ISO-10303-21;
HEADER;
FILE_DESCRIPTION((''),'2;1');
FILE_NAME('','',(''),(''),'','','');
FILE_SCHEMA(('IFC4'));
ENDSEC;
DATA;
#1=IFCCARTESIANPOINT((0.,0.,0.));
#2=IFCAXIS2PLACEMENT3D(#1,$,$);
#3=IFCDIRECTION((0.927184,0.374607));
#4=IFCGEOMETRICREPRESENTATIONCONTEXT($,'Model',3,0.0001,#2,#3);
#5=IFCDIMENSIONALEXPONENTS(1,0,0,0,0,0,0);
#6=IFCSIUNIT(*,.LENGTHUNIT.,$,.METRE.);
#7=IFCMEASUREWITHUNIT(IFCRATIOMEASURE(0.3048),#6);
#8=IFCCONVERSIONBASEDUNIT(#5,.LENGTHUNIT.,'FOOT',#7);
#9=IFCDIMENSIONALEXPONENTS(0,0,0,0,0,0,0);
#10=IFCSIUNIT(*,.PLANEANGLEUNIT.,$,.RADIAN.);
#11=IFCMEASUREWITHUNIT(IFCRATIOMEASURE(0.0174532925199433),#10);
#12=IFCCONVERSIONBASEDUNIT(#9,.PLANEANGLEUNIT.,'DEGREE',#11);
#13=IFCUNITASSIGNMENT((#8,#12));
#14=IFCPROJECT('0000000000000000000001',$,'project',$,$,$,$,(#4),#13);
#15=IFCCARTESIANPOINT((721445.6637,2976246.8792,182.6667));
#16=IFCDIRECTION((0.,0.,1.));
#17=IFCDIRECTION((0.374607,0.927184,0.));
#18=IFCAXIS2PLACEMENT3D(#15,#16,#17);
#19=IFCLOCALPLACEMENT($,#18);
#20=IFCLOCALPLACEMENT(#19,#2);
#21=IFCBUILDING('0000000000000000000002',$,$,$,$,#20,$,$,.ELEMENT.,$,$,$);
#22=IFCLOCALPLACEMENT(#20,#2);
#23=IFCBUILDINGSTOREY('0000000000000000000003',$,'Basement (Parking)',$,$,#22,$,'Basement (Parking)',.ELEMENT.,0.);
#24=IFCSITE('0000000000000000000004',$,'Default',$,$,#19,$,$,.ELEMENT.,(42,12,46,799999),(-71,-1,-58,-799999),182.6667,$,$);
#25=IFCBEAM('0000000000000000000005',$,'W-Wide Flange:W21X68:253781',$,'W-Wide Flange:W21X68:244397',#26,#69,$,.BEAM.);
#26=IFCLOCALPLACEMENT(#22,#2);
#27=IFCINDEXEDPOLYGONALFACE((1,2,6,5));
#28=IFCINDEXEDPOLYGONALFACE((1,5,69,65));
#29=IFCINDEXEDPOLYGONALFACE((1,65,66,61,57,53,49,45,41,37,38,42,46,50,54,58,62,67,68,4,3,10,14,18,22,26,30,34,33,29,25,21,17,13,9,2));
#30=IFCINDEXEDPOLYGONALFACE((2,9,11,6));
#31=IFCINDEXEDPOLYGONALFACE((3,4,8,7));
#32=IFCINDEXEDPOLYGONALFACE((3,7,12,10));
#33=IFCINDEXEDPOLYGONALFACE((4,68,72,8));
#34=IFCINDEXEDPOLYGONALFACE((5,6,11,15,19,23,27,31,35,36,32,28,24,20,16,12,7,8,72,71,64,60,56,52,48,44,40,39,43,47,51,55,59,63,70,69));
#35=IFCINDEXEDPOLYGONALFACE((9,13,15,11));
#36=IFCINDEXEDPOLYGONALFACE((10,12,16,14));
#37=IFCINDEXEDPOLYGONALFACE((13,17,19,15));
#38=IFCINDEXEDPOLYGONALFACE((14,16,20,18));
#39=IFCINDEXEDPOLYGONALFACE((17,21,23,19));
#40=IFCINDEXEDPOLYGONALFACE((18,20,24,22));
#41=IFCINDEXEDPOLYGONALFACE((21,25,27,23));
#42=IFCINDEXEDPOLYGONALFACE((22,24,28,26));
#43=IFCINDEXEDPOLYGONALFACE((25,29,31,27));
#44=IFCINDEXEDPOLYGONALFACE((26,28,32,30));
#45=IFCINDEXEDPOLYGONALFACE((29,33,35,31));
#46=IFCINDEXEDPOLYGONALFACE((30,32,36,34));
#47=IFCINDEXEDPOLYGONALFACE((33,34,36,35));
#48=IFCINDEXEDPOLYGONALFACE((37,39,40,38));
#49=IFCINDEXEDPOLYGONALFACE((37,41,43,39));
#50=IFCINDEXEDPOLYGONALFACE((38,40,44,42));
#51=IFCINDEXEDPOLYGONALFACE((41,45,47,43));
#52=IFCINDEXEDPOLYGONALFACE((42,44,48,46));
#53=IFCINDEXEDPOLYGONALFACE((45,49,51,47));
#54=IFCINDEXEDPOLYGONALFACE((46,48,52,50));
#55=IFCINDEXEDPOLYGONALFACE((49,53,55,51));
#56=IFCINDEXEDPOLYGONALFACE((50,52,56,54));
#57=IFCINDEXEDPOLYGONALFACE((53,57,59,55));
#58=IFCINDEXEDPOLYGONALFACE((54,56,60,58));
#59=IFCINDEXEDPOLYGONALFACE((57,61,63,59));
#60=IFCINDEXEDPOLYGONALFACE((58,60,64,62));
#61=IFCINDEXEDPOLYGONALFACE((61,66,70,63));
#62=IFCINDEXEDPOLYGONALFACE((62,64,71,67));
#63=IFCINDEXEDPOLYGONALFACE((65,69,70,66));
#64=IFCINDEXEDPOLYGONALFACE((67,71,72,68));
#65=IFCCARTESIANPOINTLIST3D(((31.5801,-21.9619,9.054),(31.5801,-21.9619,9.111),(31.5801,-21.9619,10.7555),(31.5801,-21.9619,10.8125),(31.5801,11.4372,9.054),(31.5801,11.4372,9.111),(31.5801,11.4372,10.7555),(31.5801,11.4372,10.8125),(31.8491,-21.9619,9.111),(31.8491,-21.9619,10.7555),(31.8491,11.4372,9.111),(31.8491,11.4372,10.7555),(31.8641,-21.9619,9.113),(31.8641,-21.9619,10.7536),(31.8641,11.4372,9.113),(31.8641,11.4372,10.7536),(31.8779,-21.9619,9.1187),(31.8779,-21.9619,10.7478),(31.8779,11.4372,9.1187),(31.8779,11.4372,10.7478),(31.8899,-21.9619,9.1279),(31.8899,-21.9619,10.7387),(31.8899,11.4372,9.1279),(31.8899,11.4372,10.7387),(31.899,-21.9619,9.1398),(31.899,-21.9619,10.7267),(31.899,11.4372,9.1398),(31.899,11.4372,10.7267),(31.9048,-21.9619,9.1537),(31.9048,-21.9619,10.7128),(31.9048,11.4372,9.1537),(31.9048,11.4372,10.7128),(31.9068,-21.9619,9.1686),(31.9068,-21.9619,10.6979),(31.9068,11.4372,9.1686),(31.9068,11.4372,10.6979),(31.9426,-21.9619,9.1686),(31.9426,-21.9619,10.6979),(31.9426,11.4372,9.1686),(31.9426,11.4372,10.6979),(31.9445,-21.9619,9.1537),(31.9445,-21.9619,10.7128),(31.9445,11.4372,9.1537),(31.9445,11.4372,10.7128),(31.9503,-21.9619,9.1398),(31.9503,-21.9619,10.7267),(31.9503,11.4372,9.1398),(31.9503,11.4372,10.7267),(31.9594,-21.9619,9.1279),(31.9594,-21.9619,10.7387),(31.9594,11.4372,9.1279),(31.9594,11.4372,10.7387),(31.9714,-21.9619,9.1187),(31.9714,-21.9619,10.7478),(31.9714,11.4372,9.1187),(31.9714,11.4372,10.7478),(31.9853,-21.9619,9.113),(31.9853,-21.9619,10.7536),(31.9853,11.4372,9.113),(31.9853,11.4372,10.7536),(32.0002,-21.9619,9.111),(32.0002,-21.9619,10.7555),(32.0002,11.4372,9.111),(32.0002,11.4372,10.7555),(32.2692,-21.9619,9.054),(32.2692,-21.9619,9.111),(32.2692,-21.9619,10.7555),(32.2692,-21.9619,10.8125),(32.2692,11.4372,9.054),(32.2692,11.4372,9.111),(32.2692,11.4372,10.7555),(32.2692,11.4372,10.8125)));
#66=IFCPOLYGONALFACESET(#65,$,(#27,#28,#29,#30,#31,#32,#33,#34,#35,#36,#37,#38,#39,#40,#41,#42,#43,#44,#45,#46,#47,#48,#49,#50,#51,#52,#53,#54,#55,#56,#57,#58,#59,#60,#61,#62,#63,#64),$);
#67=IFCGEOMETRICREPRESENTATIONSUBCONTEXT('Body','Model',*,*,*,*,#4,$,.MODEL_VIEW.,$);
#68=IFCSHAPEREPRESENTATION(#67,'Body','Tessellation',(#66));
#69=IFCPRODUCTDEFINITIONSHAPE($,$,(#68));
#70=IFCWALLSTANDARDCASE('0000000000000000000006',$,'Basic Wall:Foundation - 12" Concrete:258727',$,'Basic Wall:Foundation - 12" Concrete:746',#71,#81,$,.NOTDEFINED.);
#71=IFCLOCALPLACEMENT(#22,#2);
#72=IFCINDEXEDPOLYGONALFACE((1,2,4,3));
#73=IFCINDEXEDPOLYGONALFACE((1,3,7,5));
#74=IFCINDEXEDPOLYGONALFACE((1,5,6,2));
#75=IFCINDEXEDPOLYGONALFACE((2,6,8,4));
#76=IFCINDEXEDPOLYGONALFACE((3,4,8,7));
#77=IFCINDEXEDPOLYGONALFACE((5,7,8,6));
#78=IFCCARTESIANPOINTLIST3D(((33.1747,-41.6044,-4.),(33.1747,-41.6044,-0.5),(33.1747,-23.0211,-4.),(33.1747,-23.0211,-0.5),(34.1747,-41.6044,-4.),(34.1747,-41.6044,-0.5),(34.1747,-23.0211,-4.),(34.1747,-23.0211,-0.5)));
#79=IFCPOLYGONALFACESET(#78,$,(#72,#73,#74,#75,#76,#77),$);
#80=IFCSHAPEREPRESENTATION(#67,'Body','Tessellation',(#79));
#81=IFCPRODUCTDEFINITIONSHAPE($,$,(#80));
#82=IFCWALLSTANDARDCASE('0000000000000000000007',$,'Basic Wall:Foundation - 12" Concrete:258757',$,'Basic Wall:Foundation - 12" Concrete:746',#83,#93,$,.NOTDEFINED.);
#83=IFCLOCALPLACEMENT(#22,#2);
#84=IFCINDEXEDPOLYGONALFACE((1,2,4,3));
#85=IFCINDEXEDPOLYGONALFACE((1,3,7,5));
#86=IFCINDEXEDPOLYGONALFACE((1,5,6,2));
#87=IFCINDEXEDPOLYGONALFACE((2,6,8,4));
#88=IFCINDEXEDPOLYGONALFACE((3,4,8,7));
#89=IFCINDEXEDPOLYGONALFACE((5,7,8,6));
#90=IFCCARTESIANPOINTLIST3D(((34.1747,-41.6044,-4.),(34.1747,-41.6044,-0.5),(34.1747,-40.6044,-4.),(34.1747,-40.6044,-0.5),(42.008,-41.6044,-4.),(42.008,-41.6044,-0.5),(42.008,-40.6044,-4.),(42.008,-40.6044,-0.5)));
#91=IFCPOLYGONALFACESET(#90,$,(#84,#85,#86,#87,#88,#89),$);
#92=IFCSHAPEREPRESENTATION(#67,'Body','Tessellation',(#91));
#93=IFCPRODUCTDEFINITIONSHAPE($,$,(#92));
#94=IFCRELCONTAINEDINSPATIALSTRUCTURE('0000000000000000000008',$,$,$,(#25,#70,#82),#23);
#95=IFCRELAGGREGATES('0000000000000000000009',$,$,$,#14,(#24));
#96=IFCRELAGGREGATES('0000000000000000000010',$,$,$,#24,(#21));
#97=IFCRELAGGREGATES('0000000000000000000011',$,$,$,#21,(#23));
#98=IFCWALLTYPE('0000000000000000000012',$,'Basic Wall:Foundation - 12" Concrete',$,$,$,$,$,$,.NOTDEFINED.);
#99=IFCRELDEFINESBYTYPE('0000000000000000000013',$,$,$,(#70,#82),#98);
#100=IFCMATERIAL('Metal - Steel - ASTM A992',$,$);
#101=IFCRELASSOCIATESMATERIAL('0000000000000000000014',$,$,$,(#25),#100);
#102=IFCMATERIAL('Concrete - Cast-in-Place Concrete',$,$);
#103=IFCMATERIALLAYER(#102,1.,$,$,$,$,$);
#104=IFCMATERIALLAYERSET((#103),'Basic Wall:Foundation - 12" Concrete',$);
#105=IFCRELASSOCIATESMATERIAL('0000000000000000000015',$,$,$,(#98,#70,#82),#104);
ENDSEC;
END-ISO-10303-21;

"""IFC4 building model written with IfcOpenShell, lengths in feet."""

from ifc_helpers import new_model, entity, si_unit, converted_unit, direction, frame, frame_2d, origin, place, context, subcontext, project, spatial, polyline, rectangle, i_section, extrude, clip, bounded_halfspace, material, layer, layer_set, layer_usage, type_object, element, save


model = new_model("IFC4")

# Units and contexts
model_context = context("Model", 3, precision=0.0001, world=origin(), true_north=direction((0.927184, 0.374607)))
body_context = subcontext(model_context, "Body", "Model", "MODEL_VIEW")
ifc_project = project(units=[converted_unit("LENGTHUNIT", "FOOT", entity("IfcRatioMeasure", 0.3048), si_unit("LENGTHUNIT", "METRE"), dimensions=[1, 0, 0, 0, 0, 0, 0]), converted_unit("PLANEANGLEUNIT", "DEGREE", entity("IfcRatioMeasure", 0.0174532925199433), si_unit("PLANEANGLEUNIT", "RADIAN"), dimensions=[0, 0, 0, 0, 0, 0, 0])], contexts=[model_context])

# Site, building, storey
site_placement = place(None, frame((721445.6637, 2976246.8792, 182.6667), z_axis=(0.0, 0.0, 1.0), x_axis=(0.374607, 0.927184, 0.0)))
site = spatial("IfcSite", under=ifc_project, at=site_placement, Name="Default", CompositionType="ELEMENT", RefLatitude=(42, 12, 46, 799999), RefLongitude=(-71, -1, -58, -799999), RefElevation=182.6667)
building_placement = place(site_placement, origin())
building = spatial("IfcBuilding", under=site, at=building_placement, CompositionType="ELEMENT")
storey_placement = place(building_placement, origin())
storey = spatial("IfcBuildingStorey", under=building, at=storey_placement, Name="Basement (Parking)", LongName="Basement (Parking)", CompositionType="ELEMENT", Elevation=0.0)

# Shared definitions
ifc_material_1 = material(Name="Concrete - Cast-in-Place Concrete")

# Shared definitions
ifc_material_2 = material(Name="Metal - Steel - ASTM A992")

# Beam
beam_1_placement = place(storey_placement, frame((31.9247, -22.3544, 10.8125), z_axis=(0.0, 0.0, 1.0), x_axis=(0.0, 1.0, 0.0)))
element("IfcBeam", 1, at=beam_1_placement, inside=storey, material=ifc_material_2, Name="W-Wide Flange:W21X68:253781", ObjectType="W-Wide Flange:W21X68:244397", PredefinedType="BEAM", context=body_context, shape_type="SweptSolid", body=[
    extrude(i_section(OverallWidth=0.6891, OverallDepth=1.7585, WebThickness=0.0358, FlangeThickness=0.057, FilletRadius=0.0576, at=frame_2d((0.0, 0.0), x_axis=(0.0, 1.0))), frame((0.3926, 0.0, -0.8792), z_axis=(1.0, 0.0, 0.0), x_axis=(0.0, 0.0, -1.0)), (0.0, 0.0, 1.0), 33.3991),
])

# Walls
ifc_layer = layer(ifc_material_1, 1.0)
ifc_layer_set = layer_set([ifc_layer], Name="Basic Wall:Foundation - 12\" Concrete")
ifc_layer_usage_1 = layer_usage(ifc_layer_set, "AXIS2", "POSITIVE", -0.5)
wall_type = type_object("IfcWallType", Name="Basic Wall:Foundation - 12\" Concrete", PredefinedType="NOTDEFINED", material=ifc_layer_set)
wall_1_placement = place(storey_placement, frame((33.6747, -23.0211, -4.0), z_axis=(0.0, 0.0, 1.0), x_axis=(0.0, -1.0, 0.0)))
element("IfcWallStandardCase", 2, at=wall_1_placement, inside=storey, type_object=wall_type, material=ifc_layer_usage_1, Name="Basic Wall:Foundation - 12\" Concrete:258727", ObjectType="Basic Wall:Foundation - 12\" Concrete:746", PredefinedType="NOTDEFINED", context=body_context, shape_type="Clipping", body=[
    clip(extrude(rectangle(XDim=18.5833, YDim=1.0, at=frame_2d((9.2917, 0.0), x_axis=(-1.0, 0.0))), origin(), (0.0, 0.0, 1.0), 3.5), bounded_halfspace(frame((0.0, -0.5, 3.5), z_axis=(0.0, 0.0, -1.0), x_axis=(1.0, 0.0, 0.0)), True, frame((0.0, -0.5, 3.5)), polyline([(0.0, 0.0), (18.5833, 0.0), (18.5833, 1.0), (17.5833, 1.0), (0.0, 1.0), (0.0, 0.0)]))),
])
ifc_layer_usage_2 = layer_usage(ifc_layer_set, "AXIS2", "POSITIVE", -0.5)
wall_2_placement = place(storey_placement, frame((34.1747, -41.1044, -4.0)))
element("IfcWallStandardCase", 3, at=wall_2_placement, inside=storey, type_object=wall_type, material=ifc_layer_usage_2, Name="Basic Wall:Foundation - 12\" Concrete:258757", ObjectType="Basic Wall:Foundation - 12\" Concrete:746", PredefinedType="NOTDEFINED", context=body_context, shape_type="Clipping", body=[
    clip(extrude(rectangle(XDim=7.8333, YDim=1.0, at=frame_2d((3.9167, 0.0), x_axis=(-1.0, 0.0))), origin(), (0.0, 0.0, 1.0), 3.5), bounded_halfspace(frame((0.0, -0.5, 3.5), z_axis=(0.0, 0.0, -1.0), x_axis=(0.0, -1.0, 0.0)), True, frame((0.0, -0.5, 3.5)), polyline([(0.0, 0.0), (7.8333, 0.0), (7.8333, 1.0), (6.8333, 1.0), (0.0, 1.0), (0.0, 0.0)]))),
])

save(model, "model.ifc")
